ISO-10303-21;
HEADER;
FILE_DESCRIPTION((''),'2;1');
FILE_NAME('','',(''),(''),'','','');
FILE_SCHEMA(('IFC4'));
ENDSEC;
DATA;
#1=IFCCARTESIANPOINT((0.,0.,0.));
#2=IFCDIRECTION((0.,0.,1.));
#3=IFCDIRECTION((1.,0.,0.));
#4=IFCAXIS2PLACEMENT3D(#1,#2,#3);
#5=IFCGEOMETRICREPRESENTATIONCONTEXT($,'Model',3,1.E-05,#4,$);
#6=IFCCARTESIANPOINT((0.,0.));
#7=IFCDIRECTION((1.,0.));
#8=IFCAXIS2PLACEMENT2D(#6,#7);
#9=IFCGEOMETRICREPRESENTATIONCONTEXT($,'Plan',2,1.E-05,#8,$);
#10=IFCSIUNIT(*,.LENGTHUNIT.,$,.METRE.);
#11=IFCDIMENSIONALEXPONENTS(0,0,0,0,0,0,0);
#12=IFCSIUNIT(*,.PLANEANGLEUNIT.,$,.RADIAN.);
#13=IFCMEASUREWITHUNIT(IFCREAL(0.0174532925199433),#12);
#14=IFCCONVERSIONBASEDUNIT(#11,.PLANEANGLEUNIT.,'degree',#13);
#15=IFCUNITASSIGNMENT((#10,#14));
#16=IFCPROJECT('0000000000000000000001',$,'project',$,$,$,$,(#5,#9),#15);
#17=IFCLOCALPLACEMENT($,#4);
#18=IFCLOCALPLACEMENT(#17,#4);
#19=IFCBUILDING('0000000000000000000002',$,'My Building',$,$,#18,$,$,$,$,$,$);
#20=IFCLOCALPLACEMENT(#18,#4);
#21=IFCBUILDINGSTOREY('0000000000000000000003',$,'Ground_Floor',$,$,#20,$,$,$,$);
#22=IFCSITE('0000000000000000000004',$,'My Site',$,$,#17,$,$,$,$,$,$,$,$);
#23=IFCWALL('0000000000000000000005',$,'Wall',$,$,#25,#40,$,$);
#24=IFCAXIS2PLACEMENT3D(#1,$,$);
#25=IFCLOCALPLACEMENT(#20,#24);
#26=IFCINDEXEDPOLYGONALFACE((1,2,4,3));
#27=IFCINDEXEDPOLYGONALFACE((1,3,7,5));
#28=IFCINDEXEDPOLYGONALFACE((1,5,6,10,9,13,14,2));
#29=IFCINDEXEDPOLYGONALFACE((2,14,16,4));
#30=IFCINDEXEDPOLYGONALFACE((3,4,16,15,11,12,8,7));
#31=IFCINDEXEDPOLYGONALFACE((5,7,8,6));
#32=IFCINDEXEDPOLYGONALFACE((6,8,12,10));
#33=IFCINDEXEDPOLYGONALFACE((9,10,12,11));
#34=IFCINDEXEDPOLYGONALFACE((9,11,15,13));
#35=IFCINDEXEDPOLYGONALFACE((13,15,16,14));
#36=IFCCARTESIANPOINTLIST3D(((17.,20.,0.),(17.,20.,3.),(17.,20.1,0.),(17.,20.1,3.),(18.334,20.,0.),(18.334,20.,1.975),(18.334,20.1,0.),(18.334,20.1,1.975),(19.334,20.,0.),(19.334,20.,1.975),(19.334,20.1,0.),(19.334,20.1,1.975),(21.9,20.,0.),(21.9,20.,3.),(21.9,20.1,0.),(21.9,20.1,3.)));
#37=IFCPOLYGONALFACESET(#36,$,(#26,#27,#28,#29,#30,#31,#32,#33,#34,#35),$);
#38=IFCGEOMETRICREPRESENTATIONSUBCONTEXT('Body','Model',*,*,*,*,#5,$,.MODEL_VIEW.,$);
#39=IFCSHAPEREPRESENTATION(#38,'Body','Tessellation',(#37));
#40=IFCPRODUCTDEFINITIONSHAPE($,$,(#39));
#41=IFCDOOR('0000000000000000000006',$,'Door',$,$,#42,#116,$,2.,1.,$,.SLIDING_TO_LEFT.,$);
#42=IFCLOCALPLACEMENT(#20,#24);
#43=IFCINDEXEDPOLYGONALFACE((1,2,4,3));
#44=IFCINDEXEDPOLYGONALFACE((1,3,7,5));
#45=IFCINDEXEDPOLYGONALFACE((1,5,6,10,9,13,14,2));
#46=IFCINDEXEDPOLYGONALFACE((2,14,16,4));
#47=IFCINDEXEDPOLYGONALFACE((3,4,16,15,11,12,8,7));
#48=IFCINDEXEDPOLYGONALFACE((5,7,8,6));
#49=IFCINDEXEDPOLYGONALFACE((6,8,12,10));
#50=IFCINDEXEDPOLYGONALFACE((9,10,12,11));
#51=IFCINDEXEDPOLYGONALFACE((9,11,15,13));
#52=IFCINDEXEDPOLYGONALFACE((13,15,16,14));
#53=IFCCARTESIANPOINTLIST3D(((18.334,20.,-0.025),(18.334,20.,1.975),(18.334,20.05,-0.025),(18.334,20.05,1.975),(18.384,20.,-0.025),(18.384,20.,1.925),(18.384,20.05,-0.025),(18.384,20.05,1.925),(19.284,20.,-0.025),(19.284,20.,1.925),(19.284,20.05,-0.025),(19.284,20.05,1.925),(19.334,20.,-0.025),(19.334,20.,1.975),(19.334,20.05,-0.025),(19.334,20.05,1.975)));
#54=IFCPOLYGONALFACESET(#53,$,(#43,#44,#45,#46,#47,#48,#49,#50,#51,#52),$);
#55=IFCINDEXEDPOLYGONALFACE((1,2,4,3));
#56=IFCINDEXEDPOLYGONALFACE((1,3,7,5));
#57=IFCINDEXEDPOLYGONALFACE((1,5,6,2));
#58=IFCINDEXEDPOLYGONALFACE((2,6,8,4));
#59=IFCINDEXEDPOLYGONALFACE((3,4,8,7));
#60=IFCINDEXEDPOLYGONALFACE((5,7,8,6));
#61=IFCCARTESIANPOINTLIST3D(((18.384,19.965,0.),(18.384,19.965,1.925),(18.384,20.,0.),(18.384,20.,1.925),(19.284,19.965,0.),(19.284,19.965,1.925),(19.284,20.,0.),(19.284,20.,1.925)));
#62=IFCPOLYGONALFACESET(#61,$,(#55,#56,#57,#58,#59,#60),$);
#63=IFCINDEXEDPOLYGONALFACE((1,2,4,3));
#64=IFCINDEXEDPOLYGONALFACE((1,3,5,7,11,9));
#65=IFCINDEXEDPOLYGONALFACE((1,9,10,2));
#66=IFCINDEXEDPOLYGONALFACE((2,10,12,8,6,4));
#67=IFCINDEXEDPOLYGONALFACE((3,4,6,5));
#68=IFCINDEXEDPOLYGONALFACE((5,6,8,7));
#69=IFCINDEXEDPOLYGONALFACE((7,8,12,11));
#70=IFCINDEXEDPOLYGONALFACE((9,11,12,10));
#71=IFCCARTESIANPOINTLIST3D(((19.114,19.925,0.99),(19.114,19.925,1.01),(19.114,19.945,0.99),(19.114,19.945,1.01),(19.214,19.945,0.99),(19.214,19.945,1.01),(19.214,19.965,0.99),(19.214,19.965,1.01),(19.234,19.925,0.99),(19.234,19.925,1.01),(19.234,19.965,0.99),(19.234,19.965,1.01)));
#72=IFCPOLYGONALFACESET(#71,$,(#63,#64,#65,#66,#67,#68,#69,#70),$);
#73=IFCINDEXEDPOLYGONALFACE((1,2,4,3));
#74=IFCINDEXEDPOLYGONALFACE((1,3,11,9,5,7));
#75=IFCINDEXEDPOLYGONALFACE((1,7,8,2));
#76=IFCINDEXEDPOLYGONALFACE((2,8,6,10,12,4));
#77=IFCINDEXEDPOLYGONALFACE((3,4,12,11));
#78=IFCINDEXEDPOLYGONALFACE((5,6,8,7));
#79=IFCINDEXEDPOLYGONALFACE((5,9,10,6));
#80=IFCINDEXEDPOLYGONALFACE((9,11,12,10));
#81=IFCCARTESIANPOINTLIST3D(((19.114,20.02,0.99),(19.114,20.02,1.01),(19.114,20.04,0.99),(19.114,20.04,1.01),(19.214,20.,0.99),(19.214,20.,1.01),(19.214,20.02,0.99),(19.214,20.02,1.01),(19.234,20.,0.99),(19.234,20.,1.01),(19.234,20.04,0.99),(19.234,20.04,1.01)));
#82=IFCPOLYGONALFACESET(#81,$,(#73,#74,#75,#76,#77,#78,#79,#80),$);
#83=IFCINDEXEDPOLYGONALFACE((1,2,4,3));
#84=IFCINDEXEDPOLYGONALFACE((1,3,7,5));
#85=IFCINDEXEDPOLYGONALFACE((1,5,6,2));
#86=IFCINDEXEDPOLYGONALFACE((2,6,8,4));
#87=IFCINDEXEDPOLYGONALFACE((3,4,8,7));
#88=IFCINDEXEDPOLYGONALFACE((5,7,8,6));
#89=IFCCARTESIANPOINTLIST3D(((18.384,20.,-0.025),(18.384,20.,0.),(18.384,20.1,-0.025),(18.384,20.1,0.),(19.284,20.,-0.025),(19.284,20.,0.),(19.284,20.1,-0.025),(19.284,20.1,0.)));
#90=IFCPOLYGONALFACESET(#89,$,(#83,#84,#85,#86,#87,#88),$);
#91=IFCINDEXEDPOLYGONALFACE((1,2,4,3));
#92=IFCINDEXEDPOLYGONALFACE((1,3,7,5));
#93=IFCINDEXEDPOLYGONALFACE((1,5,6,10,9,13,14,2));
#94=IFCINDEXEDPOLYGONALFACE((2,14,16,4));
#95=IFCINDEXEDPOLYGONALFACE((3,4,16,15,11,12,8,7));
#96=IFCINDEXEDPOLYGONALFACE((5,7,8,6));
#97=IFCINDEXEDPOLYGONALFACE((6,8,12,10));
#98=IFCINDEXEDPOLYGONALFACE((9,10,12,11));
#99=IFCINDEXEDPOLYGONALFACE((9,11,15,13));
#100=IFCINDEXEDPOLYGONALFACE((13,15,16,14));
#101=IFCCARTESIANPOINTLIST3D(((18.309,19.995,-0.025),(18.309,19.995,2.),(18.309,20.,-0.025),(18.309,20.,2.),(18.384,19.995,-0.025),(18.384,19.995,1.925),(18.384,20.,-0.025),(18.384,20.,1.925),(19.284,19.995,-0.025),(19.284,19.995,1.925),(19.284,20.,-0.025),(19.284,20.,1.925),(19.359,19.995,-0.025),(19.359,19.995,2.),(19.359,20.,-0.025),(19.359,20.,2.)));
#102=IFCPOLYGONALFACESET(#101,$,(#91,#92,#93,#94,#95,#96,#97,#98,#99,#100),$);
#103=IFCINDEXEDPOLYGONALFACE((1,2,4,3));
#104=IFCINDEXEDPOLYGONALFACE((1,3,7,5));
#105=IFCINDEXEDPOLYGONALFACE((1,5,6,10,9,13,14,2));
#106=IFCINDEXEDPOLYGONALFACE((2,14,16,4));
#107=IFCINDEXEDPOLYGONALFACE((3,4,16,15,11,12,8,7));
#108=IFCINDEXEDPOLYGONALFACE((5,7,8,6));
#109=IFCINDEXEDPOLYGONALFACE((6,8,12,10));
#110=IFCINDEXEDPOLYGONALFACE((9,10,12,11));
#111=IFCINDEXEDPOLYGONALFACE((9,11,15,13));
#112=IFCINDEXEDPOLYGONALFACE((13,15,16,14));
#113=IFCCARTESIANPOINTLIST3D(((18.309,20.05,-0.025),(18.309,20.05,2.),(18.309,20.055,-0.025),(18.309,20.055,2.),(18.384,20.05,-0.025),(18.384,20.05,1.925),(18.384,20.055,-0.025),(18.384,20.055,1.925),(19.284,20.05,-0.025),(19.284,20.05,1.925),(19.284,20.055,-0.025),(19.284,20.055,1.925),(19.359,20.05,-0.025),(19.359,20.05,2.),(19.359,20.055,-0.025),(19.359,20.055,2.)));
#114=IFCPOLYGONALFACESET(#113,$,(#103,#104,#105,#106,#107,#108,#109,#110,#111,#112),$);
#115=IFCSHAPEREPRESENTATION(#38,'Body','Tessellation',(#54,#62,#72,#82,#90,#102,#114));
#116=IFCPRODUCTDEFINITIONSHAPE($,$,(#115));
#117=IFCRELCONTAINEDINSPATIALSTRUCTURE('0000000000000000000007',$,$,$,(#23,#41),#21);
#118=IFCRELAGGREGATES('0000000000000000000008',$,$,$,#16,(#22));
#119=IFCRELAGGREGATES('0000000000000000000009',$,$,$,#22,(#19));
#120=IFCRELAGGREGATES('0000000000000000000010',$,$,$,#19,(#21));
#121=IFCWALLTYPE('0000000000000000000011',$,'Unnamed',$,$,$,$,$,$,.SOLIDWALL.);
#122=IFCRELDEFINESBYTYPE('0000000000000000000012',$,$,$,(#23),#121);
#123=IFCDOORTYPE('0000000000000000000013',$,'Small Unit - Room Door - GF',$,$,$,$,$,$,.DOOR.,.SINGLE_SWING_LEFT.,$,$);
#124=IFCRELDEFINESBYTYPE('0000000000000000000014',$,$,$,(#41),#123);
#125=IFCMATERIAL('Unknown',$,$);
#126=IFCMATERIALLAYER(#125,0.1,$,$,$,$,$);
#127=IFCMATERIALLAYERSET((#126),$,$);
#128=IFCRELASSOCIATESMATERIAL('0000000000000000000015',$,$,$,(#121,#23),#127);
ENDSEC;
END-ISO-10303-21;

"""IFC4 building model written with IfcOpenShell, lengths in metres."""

from ifc_helpers import new_model, entity, si_unit, converted_unit, frame, origin_with_axes, origin_2d_with_axis, place, context, subcontext, project, spatial, line, indexed_curve, outline, extrude, shape, source, transform, mapped, material, layer, layer_set, layer_usage, type_object, type_shapes, element, fill, save


model = new_model("IFC4")

# Units and contexts
model_context = context("Model", 3, precision=1e-05, world=origin_with_axes())
plan_context = context("Plan", 2, precision=1e-05, world=origin_2d_with_axis())
body_context_1 = subcontext(model_context, "Body", "Model", "MODEL_VIEW")
body_context_2 = subcontext(plan_context, "Body", "Plan", "PLAN_VIEW")
ifc_project = project(units=[si_unit("LENGTHUNIT", "METRE"), converted_unit("PLANEANGLEUNIT", "degree", entity("IfcReal", 0.0174532925199433), si_unit("PLANEANGLEUNIT", "RADIAN"), dimensions=[0, 0, 0, 0, 0, 0, 0])], contexts=[model_context, plan_context])

# Site, building, storey
site_placement = place(None, origin_with_axes())
site = spatial("IfcSite", under=ifc_project, at=site_placement, Name="My Site")
building_placement = place(site_placement, origin_with_axes())
building = spatial("IfcBuilding", under=site, at=building_placement, Name="My Building")
storey_placement = place(building_placement, origin_with_axes())
storey = spatial("IfcBuildingStorey", under=building, at=storey_placement, Name="Ground_Floor")

# Shared definitions
ifc_material = material(Name="Unknown")
ifc_layer = layer(ifc_material, 0.1)
ifc_layer_set = layer_set([ifc_layer])
wall_type = type_object("IfcWallType", Name="Unnamed", PredefinedType="SOLIDWALL", material=ifc_layer_set)

# Shared definitions
shared_shape_1 = source(origin_with_axes(), body_context_1, "Body", "SweptSolid", [
    extrude(outline(indexed_curve([(0.0, 0.0), (1.0, 0.0), (1.0, 2.0), (0.0, 2.0)], segments=[line(1, 2, 3, 4, 1)])), frame((0.0, -0.6, 0.0), z_axis=(0.0, -1.0, 0.0), x_axis=(1.0, 0.0, 0.0)), (0.0, 0.0, -1.0), 1.2),
])
door_type_1 = type_object("IfcDoorType", Name="Small Unit - Room Door - GF", OperationType="SINGLE_SWING_LEFT", PredefinedType="DOOR")
shared_shape_2 = source(origin_with_axes(), body_context_1, "Body", "SweptSolid", [
    extrude(outline(indexed_curve([(0.0, 0.0), (0.0, 2.0), (1.0, 2.0), (1.0, 0.0), (0.95, 0.0), (0.95, 1.95), (0.05, 1.95), (0.05, 0.0)], segments=[line(1, 2, 3, 4, 5, 6, 7, 8, 1)])), frame((0.0, 0.0, 0.0), z_axis=(0.0, -1.0, 0.0), x_axis=(1.0, 0.0, 0.0)), (0.0, 0.0, -1.0), 0.05),
    extrude(outline(indexed_curve([(0.0, 0.0), (0.9, 0.0), (0.9, 0.035), (0.0, 0.035)], segments=[line(1, 2, 3, 4, 1)])), frame((0.05, -0.035, 0.025), z_axis=(0.0, 0.0, 1.0), x_axis=(1.0, 0.0, 0.0)), (0.0, 0.0, 1.0), 1.925),
    extrude(outline(indexed_curve([(0.0, 0.0), (0.0, -0.04), (-0.12, -0.04), (-0.12, -0.02), (-0.02, -0.02), (-0.02, 0.0)], segments=[line(1, 2, 3, 4, 5, 6, 1)])), frame((0.9, -0.035, 1.015), z_axis=(0.0, 0.0, 1.0), x_axis=(1.0, 0.0, 0.0)), (0.0, 0.0, 1.0), 0.02),
    extrude(outline(indexed_curve([(0.0, 0.0), (0.0, 0.04), (-0.12, 0.04), (-0.12, 0.02), (-0.02, 0.02), (-0.02, 0.0)], segments=[line(1, 2, 3, 4, 5, 6, 1)])), frame((0.9, 0.0, 1.015), z_axis=(0.0, 0.0, 1.0), x_axis=(1.0, 0.0, 0.0)), (0.0, 0.0, 1.0), 0.02),
    extrude(outline(indexed_curve([(0.0, 0.0), (0.9, 0.0), (0.9, 0.1), (0.0, 0.1)], segments=[line(1, 2, 3, 4, 1)])), frame((0.05, 0.0, 0.0), z_axis=(0.0, 0.0, 1.0), x_axis=(1.0, 0.0, 0.0)), (0.0, 0.0, 1.0), 0.025),
    extrude(outline(indexed_curve([(0.0, 0.0), (0.0, 2.025), (1.05, 2.025), (1.05, 0.0), (0.975, 0.0), (0.975, 1.95), (0.075, 1.95), (0.075, 0.0)], segments=[line(1, 2, 3, 4, 5, 6, 7, 8, 1)])), frame((-0.025, -0.005, 0.0), z_axis=(0.0, -1.0, 0.0), x_axis=(1.0, 0.0, 0.0)), (0.0, 0.0, -1.0), 0.005),
    extrude(outline(indexed_curve([(0.0, 0.0), (0.0, 2.025), (1.05, 2.025), (1.05, 0.0), (0.975, 0.0), (0.975, 1.95), (0.075, 1.95), (0.075, 0.0)], segments=[line(1, 2, 3, 4, 5, 6, 7, 8, 1)])), frame((-0.025, 0.05, 0.0), z_axis=(0.0, -1.0, 0.0), x_axis=(1.0, 0.0, 0.0)), (0.0, 0.0, -1.0), 0.005),
])
shared_shape_3 = source(origin_with_axes(), body_context_2, "Body", "Curve2D", [
    entity("IfcIndexedPolyCurve", entity("IfcCartesianPointList2D", [[0.0, 0.0], [0.05, 0.0], [0.05, 0.05], [0.0, 0.05]]), [entity("IfcLineIndex", [1, 2, 3, 4, 1])]),
    entity("IfcIndexedPolyCurve", entity("IfcCartesianPointList2D", [[1.0, 0.0], [0.95, 0.0], [0.95, 0.05], [1.0, 0.05]]), [entity("IfcLineIndex", [1, 2, 3, 4, 1])]),
    entity("IfcIndexedPolyCurve", entity("IfcCartesianPointList2D", [[-0.4, -0.035], [0.5, -0.035], [0.5, 0.0], [-0.4, 0.0]]), [entity("IfcLineIndex", [1, 2, 3, 4, 1])]),
])
type_shapes(door_type_1, [shared_shape_2, shared_shape_3])

# Wall, opening, door
ifc_layer_usage_1 = layer_usage(ifc_layer_set, "AXIS2", "POSITIVE", 0.0)
wall_1_placement = place(storey_placement, frame((17.0, 20.0, 0.0), z_axis=(0.0, 0.0, 1.0), x_axis=(1.0, 0.0, 0.0)))
wall_1 = element("IfcWall", 1, at=wall_1_placement, inside=storey, type_object=wall_type, material=ifc_layer_usage_1, Name="Wall", context=body_context_1, shape_type="SweptSolid", body=[
    extrude(outline(indexed_curve([(0.0, 0.0), (0.0, 0.1), (4.9, 0.1), (4.9, 0.0)], segments=[line(1, 2, 3, 4, 1)])), origin_with_axes(), (0.0, 0.0, 1.0), 3.0),
])
opening_1_placement = place(wall_1_placement, frame((1.334, 0.0, -0.025), z_axis=(0.0, 0.0, 1.0), x_axis=(1.0, 0.0, 0.0)))
opening_1 = element("IfcOpeningElement", 2, at=opening_1_placement, cuts=wall_1, PredefinedType="OPENING", context=body_context_1, shape_type="MappedRepresentation", body=[
    mapped(shared_shape_1, transform((0.0, 0.0, 0.0), x_axis=(1.0, 0.0, 0.0), y_axis=(0.0, 1.0, 0.0), z_axis=(0.0, 0.0, 1.0), scale=1.0)),
])
door_1_placement = place(opening_1_placement, frame((0.0, 0.0, 0.0), z_axis=(0.0, 0.0, 1.0), x_axis=(1.0, 0.0, 0.0)))
door_1 = element("IfcDoor", 3, at=door_1_placement, inside=storey, type_object=door_type_1, Name="Door", OperationType="SLIDING_TO_LEFT", OverallHeight=2.0, OverallWidth=1.0, shapes=[
    shape(body_context_1, "Body", "MappedRepresentation", [mapped(shared_shape_2, transform((0.0, 0.0, 0.0), x_axis=(1.0, 0.0, 0.0), y_axis=(0.0, 1.0, 0.0), z_axis=(0.0, 0.0, 1.0), scale=1.0))]),
    shape(body_context_2, "Body", "MappedRepresentation", [mapped(shared_shape_3, transform((0.0, 0.0, 0.0), x_axis=(1.0, 0.0, 0.0), y_axis=(0.0, 1.0, 0.0), z_axis=(0.0, 0.0, 1.0), scale=1.0))]),
])
fill(opening_1, door_1)

save(model, "model.ifc")
